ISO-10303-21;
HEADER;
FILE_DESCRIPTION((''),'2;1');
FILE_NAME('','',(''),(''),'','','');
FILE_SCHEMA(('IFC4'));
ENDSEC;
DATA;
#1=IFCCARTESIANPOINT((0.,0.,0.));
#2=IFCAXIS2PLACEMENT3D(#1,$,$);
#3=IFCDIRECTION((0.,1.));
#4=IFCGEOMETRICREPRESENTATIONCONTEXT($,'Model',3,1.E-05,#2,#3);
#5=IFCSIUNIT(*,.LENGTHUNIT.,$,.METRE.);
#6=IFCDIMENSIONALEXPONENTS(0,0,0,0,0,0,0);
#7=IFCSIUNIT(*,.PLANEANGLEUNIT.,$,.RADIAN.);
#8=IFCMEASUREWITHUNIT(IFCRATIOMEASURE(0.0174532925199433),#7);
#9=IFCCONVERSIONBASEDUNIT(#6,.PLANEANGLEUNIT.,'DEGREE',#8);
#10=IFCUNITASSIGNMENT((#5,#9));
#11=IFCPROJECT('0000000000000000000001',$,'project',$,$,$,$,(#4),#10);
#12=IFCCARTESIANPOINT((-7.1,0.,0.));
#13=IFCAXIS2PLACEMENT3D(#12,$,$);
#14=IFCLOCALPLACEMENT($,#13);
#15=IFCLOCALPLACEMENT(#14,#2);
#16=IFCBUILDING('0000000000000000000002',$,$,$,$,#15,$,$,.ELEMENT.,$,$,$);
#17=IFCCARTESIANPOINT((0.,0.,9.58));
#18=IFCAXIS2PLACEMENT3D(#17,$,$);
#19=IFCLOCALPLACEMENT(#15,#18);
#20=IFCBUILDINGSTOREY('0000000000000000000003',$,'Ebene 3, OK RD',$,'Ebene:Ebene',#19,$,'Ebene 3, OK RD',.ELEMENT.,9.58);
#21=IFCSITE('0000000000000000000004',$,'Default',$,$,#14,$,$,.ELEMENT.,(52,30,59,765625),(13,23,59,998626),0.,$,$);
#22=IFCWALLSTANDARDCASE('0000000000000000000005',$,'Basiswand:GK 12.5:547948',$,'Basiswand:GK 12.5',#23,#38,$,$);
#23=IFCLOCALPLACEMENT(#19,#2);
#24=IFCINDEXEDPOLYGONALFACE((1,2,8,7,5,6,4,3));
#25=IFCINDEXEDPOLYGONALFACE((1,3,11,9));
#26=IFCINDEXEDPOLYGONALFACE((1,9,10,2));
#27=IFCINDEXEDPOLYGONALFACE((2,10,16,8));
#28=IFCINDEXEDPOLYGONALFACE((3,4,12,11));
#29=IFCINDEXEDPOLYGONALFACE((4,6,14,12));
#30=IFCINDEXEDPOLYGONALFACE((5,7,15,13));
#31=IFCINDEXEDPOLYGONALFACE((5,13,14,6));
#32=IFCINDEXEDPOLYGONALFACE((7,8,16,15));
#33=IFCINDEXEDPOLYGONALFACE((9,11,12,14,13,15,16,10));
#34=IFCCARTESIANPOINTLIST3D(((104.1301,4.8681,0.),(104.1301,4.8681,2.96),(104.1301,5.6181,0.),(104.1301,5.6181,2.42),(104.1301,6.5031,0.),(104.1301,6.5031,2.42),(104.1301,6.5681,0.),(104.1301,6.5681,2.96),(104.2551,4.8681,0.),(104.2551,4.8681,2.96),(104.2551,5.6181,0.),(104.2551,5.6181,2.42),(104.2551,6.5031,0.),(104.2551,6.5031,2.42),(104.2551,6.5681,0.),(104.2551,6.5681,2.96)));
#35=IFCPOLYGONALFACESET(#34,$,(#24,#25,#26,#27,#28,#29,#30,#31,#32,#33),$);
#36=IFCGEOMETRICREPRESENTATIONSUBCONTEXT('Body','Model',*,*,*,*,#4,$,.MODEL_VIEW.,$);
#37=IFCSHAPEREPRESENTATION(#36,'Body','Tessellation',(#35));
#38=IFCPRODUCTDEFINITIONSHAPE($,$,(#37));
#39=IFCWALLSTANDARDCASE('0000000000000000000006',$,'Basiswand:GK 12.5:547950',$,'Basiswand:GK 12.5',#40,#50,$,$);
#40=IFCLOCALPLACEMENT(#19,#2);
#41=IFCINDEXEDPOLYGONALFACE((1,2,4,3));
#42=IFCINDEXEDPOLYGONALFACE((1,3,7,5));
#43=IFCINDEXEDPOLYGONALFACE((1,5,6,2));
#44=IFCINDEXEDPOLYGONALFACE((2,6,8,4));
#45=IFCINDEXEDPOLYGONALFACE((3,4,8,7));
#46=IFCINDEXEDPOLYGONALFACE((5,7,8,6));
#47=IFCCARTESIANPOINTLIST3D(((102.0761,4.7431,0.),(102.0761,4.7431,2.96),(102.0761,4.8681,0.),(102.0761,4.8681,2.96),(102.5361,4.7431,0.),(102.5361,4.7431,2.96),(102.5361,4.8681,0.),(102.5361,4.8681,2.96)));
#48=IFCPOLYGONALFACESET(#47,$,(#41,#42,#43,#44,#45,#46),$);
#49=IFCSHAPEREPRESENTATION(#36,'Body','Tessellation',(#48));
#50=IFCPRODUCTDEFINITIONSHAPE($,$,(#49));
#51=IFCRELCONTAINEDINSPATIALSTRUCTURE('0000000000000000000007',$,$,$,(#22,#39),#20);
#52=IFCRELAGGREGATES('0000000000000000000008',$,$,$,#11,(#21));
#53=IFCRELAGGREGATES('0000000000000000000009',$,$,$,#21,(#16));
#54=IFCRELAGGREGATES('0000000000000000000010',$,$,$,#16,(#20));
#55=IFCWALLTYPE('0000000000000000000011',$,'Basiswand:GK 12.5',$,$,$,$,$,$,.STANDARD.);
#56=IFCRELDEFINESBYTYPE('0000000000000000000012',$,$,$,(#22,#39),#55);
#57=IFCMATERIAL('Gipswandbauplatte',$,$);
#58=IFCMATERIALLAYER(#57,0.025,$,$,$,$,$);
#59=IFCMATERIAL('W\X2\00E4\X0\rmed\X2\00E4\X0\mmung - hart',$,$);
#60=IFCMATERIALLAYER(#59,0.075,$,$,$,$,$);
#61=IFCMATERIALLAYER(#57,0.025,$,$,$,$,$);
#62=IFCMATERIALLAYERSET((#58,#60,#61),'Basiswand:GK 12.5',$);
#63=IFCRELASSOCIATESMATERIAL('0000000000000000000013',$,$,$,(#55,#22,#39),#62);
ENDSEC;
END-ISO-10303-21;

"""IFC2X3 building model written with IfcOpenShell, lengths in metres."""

from ifc_helpers import new_model, entity, si_unit, converted_unit, direction, frame, frame_2d, origin, place, context, subcontext, project, spatial, rectangle, extrude, material, layer, layer_set, layer_usage, type_object, element, save


model = new_model("IFC2X3")

# Units and contexts
model_context = context("Model", 3, precision=1e-05, world=origin(), true_north=direction((0.0, 1.0)))
body_context = subcontext(model_context, "Body", "Model", "MODEL_VIEW")
ifc_project = project(units=[si_unit("LENGTHUNIT", "METRE"), converted_unit("PLANEANGLEUNIT", "DEGREE", entity("IfcRatioMeasure", 0.0174532925199433), si_unit("PLANEANGLEUNIT", "RADIAN"), dimensions=[0, 0, 0, 0, 0, 0, 0])], contexts=[model_context])

# Site, building, storey
site_placement = place(None, frame((-7.1, 0.0, 0.0)))
site = spatial("IfcSite", under=ifc_project, at=site_placement, Name="Default", CompositionType="ELEMENT", RefLatitude=(52, 30, 59, 765625), RefLongitude=(13, 23, 59, 998626), RefElevation=0.0)
building_placement = place(site_placement, origin())
building = spatial("IfcBuilding", under=site, at=building_placement, CompositionType="ELEMENT")
storey_placement = place(building_placement, frame((0.0, 0.0, 9.58)))
storey = spatial("IfcBuildingStorey", under=building, at=storey_placement, Name="Ebene 3, OK RD", ObjectType="Ebene:Ebene", LongName="Ebene 3, OK RD", CompositionType="ELEMENT", Elevation=9.58)

# Shared definitions
ifc_material_1 = material(Name="Gipswandbauplatte")
ifc_layer_1 = layer(ifc_material_1, 0.025)
ifc_material_2 = material(Name="Wärmedämmung - hart")
ifc_layer_2 = layer(ifc_material_2, 0.075)
ifc_layer_3 = layer(ifc_material_1, 0.025)
ifc_layer_set_1 = layer_set([ifc_layer_1, ifc_layer_2, ifc_layer_3], Name="Basiswand:GK 12.5")
wall_type_1 = type_object("IfcWallType", Name="Basiswand:GK 12.5", PredefinedType="STANDARD", material=ifc_layer_set_1)

# Wall, opening
ifc_layer_usage_1 = layer_usage(ifc_layer_set_1, "AXIS2", "NEGATIVE", 0.0625)
wall_1_placement = place(storey_placement, frame((104.1926, 6.5681, 0.0), z_axis=(0.0, 0.0, 1.0), x_axis=(0.0, -1.0, 0.0)))
wall_1 = element("IfcWallStandardCase", 1, at=wall_1_placement, inside=storey, type_object=wall_type_1, material=ifc_layer_usage_1, Name="Basiswand:GK 12.5:547948", ObjectType="Basiswand:GK 12.5", context=body_context, shape_type="SweptSolid", body=[
    extrude(rectangle(XDim=1.7, YDim=0.125, at=frame_2d((0.85, 0.0), x_axis=(-1.0, 0.0))), origin(), (0.0, 0.0, 1.0), 2.96),
])
opening_placement = place(wall_1_placement, frame((0.065, -0.0625, 0.0)))
element("IfcOpeningElement", 2, at=opening_placement, cuts=wall_1, ObjectType="Opening", context=body_context, shape_type="SweptSolid", body=[
    extrude(rectangle(XDim=2.42, YDim=0.885, at=frame_2d((1.21, 0.4425), x_axis=(1.0, 0.0))), frame((0.0, 0.0, 0.0), z_axis=(0.0, 1.0, 0.0), x_axis=(0.0, 0.0, 1.0)), (0.0, 0.0, 1.0), 0.125),
])

# Wall
ifc_layer_usage_2 = layer_usage(ifc_layer_set_1, "AXIS2", "NEGATIVE", 0.0625)
wall_2_placement = place(storey_placement, frame((102.0761, 4.8056, 0.0)))
element("IfcWallStandardCase", 3, at=wall_2_placement, inside=storey, type_object=wall_type_1, material=ifc_layer_usage_2, Name="Basiswand:GK 12.5:547950", ObjectType="Basiswand:GK 12.5", context=body_context, shape_type="SweptSolid", body=[
    extrude(rectangle(XDim=0.46, YDim=0.125, at=frame_2d((0.23, 0.0), x_axis=(-1.0, 0.0))), origin(), (0.0, 0.0, 1.0), 2.96),
])

save(model, "model.ifc")
